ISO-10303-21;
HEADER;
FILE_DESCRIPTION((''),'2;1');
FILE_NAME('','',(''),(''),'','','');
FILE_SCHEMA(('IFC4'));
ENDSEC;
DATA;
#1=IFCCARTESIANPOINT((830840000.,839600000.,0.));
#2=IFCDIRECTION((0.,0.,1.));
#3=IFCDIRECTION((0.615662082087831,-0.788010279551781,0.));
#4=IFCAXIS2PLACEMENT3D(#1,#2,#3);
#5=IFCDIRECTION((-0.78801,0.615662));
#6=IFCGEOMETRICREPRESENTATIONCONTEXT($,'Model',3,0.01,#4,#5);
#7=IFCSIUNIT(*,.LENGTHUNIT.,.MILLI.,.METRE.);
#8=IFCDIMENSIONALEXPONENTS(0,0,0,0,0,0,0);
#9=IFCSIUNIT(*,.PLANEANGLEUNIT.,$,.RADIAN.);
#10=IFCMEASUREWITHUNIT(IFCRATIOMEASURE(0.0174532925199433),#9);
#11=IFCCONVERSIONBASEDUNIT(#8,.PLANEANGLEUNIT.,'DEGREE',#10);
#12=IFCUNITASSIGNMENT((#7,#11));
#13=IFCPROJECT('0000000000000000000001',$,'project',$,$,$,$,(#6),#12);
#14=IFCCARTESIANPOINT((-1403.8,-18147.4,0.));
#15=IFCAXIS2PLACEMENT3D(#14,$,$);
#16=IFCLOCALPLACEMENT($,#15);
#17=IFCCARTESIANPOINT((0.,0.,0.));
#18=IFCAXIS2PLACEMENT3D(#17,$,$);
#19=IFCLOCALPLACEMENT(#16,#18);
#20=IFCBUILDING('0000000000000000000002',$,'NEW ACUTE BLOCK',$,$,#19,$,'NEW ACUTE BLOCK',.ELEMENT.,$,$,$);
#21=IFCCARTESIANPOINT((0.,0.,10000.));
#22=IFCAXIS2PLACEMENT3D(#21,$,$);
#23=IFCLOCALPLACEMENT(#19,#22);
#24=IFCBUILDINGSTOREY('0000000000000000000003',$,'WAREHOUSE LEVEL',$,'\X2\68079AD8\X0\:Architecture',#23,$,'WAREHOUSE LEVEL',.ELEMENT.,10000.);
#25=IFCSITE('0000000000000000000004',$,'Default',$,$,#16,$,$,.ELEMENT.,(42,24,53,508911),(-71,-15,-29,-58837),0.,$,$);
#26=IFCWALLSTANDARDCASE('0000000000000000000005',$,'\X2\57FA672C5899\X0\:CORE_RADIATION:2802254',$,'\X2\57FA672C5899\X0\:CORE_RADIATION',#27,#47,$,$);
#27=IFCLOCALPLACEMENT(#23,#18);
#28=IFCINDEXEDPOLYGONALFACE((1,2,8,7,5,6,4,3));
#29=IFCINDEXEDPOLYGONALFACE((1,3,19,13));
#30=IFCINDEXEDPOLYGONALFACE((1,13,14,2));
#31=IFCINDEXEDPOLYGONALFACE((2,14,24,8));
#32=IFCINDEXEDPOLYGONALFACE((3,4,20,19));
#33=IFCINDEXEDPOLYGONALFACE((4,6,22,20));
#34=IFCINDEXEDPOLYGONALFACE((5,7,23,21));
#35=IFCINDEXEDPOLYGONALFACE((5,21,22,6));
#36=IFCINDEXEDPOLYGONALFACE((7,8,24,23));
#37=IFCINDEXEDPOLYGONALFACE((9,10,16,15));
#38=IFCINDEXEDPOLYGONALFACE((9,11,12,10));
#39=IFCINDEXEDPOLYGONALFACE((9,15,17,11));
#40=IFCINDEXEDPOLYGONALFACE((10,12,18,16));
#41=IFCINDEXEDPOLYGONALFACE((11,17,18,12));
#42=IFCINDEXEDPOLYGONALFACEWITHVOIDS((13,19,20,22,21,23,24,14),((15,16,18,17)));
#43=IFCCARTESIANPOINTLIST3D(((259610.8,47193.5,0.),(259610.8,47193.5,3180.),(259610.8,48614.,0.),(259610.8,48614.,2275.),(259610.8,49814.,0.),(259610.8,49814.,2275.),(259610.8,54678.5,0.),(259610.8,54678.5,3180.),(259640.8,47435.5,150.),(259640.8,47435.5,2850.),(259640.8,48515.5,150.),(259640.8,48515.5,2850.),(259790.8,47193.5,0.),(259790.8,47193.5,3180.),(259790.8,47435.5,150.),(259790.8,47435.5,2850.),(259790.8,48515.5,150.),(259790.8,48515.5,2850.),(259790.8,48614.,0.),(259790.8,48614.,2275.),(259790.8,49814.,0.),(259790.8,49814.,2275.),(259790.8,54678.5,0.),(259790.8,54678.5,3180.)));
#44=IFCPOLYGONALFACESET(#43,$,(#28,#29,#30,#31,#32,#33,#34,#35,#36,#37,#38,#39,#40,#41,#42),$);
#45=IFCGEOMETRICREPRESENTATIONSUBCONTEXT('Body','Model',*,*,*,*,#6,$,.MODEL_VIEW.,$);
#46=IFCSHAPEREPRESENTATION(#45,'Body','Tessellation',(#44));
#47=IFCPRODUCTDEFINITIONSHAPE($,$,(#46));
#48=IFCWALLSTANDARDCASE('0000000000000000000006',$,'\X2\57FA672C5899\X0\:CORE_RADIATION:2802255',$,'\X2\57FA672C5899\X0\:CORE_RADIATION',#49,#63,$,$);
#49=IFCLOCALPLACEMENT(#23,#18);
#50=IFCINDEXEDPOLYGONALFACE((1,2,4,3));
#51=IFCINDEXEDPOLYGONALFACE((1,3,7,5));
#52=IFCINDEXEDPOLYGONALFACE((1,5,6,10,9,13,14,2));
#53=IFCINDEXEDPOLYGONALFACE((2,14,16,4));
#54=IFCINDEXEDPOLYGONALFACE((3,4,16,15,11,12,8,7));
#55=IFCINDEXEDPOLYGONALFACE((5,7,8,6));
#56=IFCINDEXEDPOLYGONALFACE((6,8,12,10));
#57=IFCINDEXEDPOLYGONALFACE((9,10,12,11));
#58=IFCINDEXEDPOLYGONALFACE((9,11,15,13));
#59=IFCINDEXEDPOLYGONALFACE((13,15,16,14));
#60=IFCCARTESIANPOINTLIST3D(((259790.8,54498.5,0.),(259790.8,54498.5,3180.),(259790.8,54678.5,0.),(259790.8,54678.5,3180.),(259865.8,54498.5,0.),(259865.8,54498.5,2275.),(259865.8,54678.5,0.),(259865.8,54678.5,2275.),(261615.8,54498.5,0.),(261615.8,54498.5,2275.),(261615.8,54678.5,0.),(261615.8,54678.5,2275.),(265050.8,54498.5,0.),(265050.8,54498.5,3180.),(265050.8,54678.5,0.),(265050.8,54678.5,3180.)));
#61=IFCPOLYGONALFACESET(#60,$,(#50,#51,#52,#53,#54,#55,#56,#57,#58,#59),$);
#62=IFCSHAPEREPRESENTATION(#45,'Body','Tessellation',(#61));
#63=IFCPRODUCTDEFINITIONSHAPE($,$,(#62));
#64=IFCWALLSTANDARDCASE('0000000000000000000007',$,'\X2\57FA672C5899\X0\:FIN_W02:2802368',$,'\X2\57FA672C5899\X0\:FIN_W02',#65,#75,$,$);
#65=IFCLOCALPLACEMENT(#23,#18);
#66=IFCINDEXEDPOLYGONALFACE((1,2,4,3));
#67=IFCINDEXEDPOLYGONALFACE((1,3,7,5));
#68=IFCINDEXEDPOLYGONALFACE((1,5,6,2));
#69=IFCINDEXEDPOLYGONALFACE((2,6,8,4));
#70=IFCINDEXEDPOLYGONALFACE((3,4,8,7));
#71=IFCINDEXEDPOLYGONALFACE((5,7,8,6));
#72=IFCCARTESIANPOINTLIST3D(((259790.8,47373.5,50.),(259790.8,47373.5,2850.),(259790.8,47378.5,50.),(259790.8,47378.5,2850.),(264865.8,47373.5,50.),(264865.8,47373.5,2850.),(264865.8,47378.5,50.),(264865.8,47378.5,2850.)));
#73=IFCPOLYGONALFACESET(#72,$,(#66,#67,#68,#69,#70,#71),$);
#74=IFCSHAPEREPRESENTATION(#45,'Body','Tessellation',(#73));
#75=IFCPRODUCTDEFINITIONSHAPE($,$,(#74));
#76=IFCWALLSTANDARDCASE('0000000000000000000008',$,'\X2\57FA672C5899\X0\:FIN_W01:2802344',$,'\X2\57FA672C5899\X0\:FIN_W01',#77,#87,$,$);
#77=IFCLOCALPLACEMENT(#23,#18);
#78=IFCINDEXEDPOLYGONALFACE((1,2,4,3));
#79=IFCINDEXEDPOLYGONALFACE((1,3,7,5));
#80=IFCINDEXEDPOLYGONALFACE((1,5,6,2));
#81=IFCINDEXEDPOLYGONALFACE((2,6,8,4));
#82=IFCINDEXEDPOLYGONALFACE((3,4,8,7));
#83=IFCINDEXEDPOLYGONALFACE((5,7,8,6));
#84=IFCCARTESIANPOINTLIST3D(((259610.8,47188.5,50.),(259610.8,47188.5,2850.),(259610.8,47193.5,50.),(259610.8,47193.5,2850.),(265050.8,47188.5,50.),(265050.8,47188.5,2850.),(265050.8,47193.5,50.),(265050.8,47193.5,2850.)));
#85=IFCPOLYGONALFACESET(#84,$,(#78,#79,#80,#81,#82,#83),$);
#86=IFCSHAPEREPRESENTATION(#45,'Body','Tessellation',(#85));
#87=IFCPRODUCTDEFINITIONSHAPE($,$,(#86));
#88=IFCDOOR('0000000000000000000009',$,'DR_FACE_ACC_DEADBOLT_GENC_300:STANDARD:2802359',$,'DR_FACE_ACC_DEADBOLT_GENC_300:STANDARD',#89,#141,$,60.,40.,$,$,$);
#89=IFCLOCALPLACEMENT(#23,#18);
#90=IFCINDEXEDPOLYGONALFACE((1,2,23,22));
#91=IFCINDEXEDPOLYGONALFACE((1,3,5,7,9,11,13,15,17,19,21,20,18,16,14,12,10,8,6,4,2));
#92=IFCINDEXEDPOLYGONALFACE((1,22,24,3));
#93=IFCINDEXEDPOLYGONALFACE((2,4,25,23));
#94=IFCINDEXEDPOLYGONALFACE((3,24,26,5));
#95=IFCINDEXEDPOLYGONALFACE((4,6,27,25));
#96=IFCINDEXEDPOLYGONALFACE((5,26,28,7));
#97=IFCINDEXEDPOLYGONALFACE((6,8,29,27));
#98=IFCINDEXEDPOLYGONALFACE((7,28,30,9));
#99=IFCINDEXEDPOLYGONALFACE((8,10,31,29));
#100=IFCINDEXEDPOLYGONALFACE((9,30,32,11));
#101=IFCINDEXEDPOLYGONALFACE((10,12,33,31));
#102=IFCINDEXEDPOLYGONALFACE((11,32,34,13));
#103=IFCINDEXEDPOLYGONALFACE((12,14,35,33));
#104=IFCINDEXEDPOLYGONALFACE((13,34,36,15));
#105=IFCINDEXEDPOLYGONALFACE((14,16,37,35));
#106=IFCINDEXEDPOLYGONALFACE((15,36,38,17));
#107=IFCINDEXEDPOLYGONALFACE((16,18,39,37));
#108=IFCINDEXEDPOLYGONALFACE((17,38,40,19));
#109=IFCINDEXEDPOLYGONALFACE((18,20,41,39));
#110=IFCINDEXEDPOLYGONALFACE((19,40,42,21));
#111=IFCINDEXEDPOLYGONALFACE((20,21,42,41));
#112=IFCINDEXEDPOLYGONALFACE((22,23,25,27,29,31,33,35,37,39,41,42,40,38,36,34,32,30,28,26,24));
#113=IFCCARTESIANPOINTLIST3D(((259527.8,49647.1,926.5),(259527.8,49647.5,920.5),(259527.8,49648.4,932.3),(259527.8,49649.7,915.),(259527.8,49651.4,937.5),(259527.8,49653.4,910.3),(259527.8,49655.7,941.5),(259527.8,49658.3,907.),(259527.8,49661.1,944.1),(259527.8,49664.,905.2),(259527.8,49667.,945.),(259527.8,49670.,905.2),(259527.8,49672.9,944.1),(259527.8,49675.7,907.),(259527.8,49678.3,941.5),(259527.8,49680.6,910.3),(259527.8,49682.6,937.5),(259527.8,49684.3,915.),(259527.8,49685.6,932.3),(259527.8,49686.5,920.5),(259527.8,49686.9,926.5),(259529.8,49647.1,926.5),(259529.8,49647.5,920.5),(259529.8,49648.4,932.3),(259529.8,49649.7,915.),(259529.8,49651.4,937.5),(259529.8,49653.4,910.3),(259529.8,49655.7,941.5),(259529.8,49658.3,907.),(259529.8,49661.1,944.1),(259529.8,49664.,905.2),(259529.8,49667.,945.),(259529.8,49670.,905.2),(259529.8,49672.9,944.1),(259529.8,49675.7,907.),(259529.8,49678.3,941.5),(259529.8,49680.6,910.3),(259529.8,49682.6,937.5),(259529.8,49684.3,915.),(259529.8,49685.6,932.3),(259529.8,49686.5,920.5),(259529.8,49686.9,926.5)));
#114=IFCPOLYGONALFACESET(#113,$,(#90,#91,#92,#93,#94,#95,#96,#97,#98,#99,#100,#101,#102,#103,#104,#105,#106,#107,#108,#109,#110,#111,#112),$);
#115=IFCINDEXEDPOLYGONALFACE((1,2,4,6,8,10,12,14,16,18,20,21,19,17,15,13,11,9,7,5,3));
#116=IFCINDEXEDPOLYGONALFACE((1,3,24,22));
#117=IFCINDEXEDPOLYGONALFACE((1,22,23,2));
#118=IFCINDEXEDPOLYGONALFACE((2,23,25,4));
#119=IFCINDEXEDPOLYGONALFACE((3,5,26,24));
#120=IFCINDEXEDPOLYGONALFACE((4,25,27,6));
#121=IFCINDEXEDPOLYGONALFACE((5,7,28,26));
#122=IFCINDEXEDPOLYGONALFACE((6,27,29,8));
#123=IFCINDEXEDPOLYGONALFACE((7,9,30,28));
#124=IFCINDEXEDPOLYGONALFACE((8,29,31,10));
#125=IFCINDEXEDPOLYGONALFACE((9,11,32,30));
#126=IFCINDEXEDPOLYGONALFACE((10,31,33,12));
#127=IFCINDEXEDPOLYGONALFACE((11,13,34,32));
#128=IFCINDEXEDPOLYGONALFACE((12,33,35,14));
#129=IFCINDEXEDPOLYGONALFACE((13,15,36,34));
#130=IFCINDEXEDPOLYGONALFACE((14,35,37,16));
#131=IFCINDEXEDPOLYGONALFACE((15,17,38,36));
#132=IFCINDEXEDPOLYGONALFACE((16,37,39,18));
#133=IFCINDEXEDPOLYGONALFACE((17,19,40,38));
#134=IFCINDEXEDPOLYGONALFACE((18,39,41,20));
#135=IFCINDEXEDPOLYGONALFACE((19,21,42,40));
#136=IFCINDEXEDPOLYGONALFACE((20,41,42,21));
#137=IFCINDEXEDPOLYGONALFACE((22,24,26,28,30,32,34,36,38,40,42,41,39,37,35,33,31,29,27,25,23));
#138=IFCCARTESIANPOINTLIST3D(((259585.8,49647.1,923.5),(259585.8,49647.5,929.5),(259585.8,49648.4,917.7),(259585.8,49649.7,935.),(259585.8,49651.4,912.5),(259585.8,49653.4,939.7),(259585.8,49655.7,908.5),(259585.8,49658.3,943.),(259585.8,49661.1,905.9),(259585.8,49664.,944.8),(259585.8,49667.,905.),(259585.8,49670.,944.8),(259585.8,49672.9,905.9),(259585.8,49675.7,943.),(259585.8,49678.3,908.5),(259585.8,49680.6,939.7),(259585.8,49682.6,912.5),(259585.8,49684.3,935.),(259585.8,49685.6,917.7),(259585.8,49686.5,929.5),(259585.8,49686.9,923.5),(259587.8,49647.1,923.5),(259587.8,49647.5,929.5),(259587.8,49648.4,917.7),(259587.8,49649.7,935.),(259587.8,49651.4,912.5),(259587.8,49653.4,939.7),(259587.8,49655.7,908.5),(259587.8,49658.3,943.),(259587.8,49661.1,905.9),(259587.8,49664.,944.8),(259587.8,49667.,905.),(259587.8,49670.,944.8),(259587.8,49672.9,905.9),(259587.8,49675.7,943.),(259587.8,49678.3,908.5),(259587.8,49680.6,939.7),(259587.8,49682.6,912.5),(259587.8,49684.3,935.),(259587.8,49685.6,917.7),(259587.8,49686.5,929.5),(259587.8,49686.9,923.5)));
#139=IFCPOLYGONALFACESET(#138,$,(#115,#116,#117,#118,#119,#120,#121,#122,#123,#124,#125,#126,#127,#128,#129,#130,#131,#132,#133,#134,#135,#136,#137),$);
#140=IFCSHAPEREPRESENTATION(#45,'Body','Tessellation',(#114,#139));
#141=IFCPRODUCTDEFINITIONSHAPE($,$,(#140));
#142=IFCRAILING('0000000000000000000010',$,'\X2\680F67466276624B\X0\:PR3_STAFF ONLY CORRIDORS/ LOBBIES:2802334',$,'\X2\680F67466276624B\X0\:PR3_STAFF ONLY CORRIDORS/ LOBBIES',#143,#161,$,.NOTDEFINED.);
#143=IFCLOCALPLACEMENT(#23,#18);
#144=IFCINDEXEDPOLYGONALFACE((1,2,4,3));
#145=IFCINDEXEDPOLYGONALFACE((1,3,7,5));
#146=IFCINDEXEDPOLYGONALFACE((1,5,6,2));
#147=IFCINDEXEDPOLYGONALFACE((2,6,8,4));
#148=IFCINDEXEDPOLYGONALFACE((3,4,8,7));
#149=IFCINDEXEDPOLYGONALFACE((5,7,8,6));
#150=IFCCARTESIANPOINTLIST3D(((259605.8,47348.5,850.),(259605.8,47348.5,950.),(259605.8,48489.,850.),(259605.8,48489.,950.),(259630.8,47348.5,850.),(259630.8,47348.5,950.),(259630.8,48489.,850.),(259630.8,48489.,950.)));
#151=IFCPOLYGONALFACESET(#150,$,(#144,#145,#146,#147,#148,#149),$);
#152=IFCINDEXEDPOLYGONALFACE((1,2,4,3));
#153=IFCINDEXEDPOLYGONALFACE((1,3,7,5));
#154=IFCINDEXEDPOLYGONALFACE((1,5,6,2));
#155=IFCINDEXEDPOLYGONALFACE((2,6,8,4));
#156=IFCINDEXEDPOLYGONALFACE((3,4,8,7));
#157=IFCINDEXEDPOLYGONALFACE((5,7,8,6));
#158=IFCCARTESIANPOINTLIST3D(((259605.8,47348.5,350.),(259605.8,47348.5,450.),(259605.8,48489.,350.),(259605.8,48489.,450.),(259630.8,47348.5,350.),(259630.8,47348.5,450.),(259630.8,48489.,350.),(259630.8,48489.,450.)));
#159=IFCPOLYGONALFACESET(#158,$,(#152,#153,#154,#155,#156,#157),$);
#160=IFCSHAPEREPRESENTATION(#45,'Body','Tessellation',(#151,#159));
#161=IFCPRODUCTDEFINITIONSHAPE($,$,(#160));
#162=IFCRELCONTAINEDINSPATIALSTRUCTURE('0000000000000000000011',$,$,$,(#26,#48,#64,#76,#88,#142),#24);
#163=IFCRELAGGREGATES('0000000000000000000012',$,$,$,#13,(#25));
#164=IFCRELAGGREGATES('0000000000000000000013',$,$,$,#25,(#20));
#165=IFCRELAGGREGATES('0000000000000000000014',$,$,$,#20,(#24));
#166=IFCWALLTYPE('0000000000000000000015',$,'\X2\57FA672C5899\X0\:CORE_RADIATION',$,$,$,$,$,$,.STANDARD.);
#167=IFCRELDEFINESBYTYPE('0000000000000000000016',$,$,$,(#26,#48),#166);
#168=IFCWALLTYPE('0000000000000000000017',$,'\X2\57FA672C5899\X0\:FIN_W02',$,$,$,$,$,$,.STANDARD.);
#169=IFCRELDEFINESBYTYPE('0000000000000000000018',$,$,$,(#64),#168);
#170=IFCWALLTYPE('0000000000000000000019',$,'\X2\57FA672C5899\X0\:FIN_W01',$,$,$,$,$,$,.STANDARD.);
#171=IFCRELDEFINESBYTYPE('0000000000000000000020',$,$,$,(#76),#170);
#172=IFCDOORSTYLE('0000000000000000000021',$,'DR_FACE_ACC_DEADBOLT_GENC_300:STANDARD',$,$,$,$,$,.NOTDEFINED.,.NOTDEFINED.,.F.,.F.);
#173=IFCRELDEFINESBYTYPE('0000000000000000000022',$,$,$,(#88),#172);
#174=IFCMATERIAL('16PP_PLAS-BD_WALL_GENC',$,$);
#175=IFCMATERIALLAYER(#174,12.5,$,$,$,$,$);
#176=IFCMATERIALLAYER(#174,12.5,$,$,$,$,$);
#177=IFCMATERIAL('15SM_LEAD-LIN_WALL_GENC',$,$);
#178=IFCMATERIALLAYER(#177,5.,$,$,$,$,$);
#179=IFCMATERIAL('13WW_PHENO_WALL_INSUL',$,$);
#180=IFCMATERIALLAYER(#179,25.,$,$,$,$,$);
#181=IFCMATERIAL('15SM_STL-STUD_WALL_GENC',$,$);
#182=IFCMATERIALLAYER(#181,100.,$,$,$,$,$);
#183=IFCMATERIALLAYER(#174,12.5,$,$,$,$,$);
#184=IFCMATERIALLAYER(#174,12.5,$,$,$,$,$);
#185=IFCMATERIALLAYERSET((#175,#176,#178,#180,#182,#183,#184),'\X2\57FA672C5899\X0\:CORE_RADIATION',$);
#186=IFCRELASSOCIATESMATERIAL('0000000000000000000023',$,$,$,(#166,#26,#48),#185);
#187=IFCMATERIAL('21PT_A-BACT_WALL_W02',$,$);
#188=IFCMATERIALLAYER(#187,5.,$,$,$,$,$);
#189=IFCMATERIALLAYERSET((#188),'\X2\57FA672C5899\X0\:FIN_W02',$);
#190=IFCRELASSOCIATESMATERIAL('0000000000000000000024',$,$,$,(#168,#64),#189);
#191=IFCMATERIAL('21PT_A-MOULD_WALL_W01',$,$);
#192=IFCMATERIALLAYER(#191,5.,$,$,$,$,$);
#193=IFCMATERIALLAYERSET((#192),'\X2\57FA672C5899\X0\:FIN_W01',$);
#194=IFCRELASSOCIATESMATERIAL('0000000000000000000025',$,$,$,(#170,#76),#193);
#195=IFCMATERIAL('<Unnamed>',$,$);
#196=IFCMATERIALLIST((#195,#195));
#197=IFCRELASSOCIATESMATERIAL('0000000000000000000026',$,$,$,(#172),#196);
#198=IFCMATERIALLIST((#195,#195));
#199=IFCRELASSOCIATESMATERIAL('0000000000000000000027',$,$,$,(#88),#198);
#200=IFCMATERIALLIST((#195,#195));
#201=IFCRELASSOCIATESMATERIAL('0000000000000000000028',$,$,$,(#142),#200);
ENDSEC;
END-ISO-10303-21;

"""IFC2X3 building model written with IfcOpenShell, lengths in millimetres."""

from ifc_helpers import new_model, entity, si_unit, converted_unit, direction, frame, frame_2d, origin, place, context, subcontext, project, spatial, rectangle, circle, extrude, source, transform, mapped, material, material_list, layer, layer_set, layer_usage, type_object, type_shapes, element, save


model = new_model("IFC2X3")

# Units and contexts
model_context = context("Model", 3, precision=0.01, world=frame((830840000.0, 839600000.0, 0.0), z_axis=(0.0, 0.0, 1.0), x_axis=(0.615662082087831, -0.788010279551781, 0.0)), true_north=direction((-0.78801, 0.615662)))
body_context = subcontext(model_context, "Body", "Model", "MODEL_VIEW")
ifc_project = project(units=[si_unit("LENGTHUNIT", "METRE", prefix="MILLI"), converted_unit("PLANEANGLEUNIT", "DEGREE", entity("IfcRatioMeasure", 0.0174532925199433), si_unit("PLANEANGLEUNIT", "RADIAN"), dimensions=[0, 0, 0, 0, 0, 0, 0])], contexts=[model_context])

# Site, building, storey
site_placement = place(None, frame((-1403.8, -18147.4, 0.0)))
site = spatial("IfcSite", under=ifc_project, at=site_placement, Name="Default", CompositionType="ELEMENT", RefLatitude=(42, 24, 53, 508911), RefLongitude=(-71, -15, -29, -58837), RefElevation=0.0)
building_placement = place(site_placement, origin())
building = spatial("IfcBuilding", under=site, at=building_placement, Name="NEW ACUTE BLOCK", LongName="NEW ACUTE BLOCK", CompositionType="ELEMENT")
storey_placement = place(building_placement, frame((0.0, 0.0, 10000.0)))
storey = spatial("IfcBuildingStorey", under=building, at=storey_placement, Name="WAREHOUSE LEVEL", ObjectType="标高:Architecture", LongName="WAREHOUSE LEVEL", CompositionType="ELEMENT", Elevation=10000.0)

# Wall, openings
ifc_material_1 = material(Name="16PP_PLAS-BD_WALL_GENC")
ifc_layer_1 = layer(ifc_material_1, 12.5)
ifc_layer_2 = layer(ifc_material_1, 12.5)
ifc_material_2 = material(Name="15SM_LEAD-LIN_WALL_GENC")
ifc_layer_3 = layer(ifc_material_2, 5.0)
ifc_material_3 = material(Name="13WW_PHENO_WALL_INSUL")
ifc_layer_4 = layer(ifc_material_3, 25.0)
ifc_material_4 = material(Name="15SM_STL-STUD_WALL_GENC")
ifc_layer_5 = layer(ifc_material_4, 100.0)
ifc_layer_6 = layer(ifc_material_1, 12.5)
ifc_layer_7 = layer(ifc_material_1, 12.5)
ifc_layer_set_1 = layer_set([ifc_layer_1, ifc_layer_2, ifc_layer_3, ifc_layer_4, ifc_layer_5, ifc_layer_6, ifc_layer_7], Name="基本墙:CORE_RADIATION")
ifc_layer_usage_1 = layer_usage(ifc_layer_set_1, "AXIS2", "POSITIVE", -90.0)
wall_type_1 = type_object("IfcWallType", Name="基本墙:CORE_RADIATION", PredefinedType="STANDARD", material=ifc_layer_set_1)
wall_1_placement = place(storey_placement, frame((259700.8, 54678.5, 0.0), z_axis=(0.0, 0.0, 1.0), x_axis=(0.0, -1.0, 0.0)))
wall_1 = element("IfcWallStandardCase", 1, at=wall_1_placement, inside=storey, type_object=wall_type_1, material=ifc_layer_usage_1, Name="基本墙:CORE_RADIATION:2802254", ObjectType="基本墙:CORE_RADIATION", context=body_context, shape_type="SweptSolid", body=[
    extrude(rectangle(XDim=7485.0, YDim=180.0, at=frame_2d((3742.5, 0.0), x_axis=(-1.0, 0.0))), origin(), (0.0, 0.0, 1.0), 3180.0),
])
opening_1_placement = place(wall_1_placement, frame((7243.0, -60.0, 150.0)))
element("IfcOpeningElement", 2, at=opening_1_placement, cuts=wall_1, ObjectType="Recess", context=body_context, shape_type="SweptSolid", body=[
    extrude(rectangle(XDim=2700.0, YDim=1080.0, at=frame_2d((0.0, 0.0), x_axis=(0.0, 1.0))), frame((-540.0, 0.0, 1350.0), z_axis=(0.0, 1.0, 0.0), x_axis=(1.0, 0.0, 0.0)), (0.0, 0.0, 1.0), 155.0),
])
opening_2_placement = place(wall_1_placement, frame((6064.5, -90.0, 0.0), z_axis=(0.0, 0.0, 1.0), x_axis=(0.0, 1.0, 0.0)))
element("IfcOpeningElement", 3, at=opening_2_placement, cuts=wall_1, ObjectType="Opening", context=body_context, shape_type="SweptSolid", body=[
    extrude(rectangle(XDim=2275.0, YDim=1200.0, at=frame_2d((0.0, 0.0), x_axis=(1.0, 0.0))), frame((0.0, 600.0, 1137.5), z_axis=(1.0, 0.0, 0.0), x_axis=(0.0, 0.0, -1.0)), (0.0, 0.0, 1.0), 180.0),
])

# Wall, opening
ifc_layer_usage_2 = layer_usage(ifc_layer_set_1, "AXIS2", "NEGATIVE", 90.0)
wall_2_placement = place(storey_placement, frame((259790.8, 54588.5, 0.0)))
wall_2 = element("IfcWallStandardCase", 4, at=wall_2_placement, inside=storey, type_object=wall_type_1, material=ifc_layer_usage_2, Name="基本墙:CORE_RADIATION:2802255", ObjectType="基本墙:CORE_RADIATION", context=body_context, shape_type="SweptSolid", body=[
    extrude(rectangle(XDim=5260.0, YDim=180.0, at=frame_2d((2630.0, 0.0), x_axis=(-1.0, 0.0))), origin(), (0.0, 0.0, 1.0), 3180.0),
])
opening_3_placement = place(wall_2_placement, frame((75.0, -90.0, 0.0)))
element("IfcOpeningElement", 5, at=opening_3_placement, cuts=wall_2, ObjectType="Opening", context=body_context, shape_type="SweptSolid", body=[
    extrude(rectangle(XDim=2275.0, YDim=1750.0, at=frame_2d((0.0, 0.0), x_axis=(1.0, 0.0))), frame((875.0, 0.0, 1137.5), z_axis=(0.0, 1.0, 0.0), x_axis=(0.0, 0.0, -1.0)), (0.0, 0.0, 1.0), 180.0),
])

# Shared definitions
ifc_material_5 = material(Name="21PT_A-BACT_WALL_W02")
ifc_layer_8 = layer(ifc_material_5, 5.0)
ifc_layer_set_2 = layer_set([ifc_layer_8], Name="基本墙:FIN_W02")
wall_type_2 = type_object("IfcWallType", Name="基本墙:FIN_W02", PredefinedType="STANDARD", material=ifc_layer_set_2)

# Wall
ifc_layer_usage_3 = layer_usage(ifc_layer_set_2, "AXIS2", "NEGATIVE", 2.5)
wall_3_placement = place(storey_placement, frame((259790.8, 47376.0, 50.0)))
element("IfcWallStandardCase", 6, at=wall_3_placement, inside=storey, type_object=wall_type_2, material=ifc_layer_usage_3, Name="基本墙:FIN_W02:2802368", ObjectType="基本墙:FIN_W02", context=body_context, shape_type="SweptSolid", body=[
    extrude(rectangle(XDim=5075.0, YDim=5.0, at=frame_2d((2537.5, 0.0), x_axis=(-1.0, 0.0))), origin(), (0.0, 0.0, 1.0), 2800.0),
])

# Shared definitions
ifc_material_6 = material(Name="21PT_A-MOULD_WALL_W01")
ifc_layer_9 = layer(ifc_material_6, 5.0)
ifc_layer_set_3 = layer_set([ifc_layer_9], Name="基本墙:FIN_W01")
wall_type_3 = type_object("IfcWallType", Name="基本墙:FIN_W01", PredefinedType="STANDARD", material=ifc_layer_set_3)

# Wall
ifc_layer_usage_4 = layer_usage(ifc_layer_set_3, "AXIS2", "POSITIVE", -2.5)
wall_4_placement = place(storey_placement, frame((259610.8, 47191.0, 50.0)))
element("IfcWallStandardCase", 7, at=wall_4_placement, inside=storey, type_object=wall_type_3, material=ifc_layer_usage_4, Name="基本墙:FIN_W01:2802344", ObjectType="基本墙:FIN_W01", context=body_context, shape_type="SweptSolid", body=[
    extrude(rectangle(XDim=5440.0, YDim=5.0, at=frame_2d((2720.0, 0.0), x_axis=(-1.0, 0.0))), origin(), (0.0, 0.0, 1.0), 2800.0),
])

# Door
ifc_material_7 = material(Name="<Unnamed>")
ifc_material_list_1 = material_list([ifc_material_7, ifc_material_7])
ifc_material_list_2 = material_list([ifc_material_7, ifc_material_7])
door_style_1 = type_object("IfcDoorStyle", Name="DR_FACE_ACC_DEADBOLT_GENC_300:STANDARD", ConstructionType="NOTDEFINED", OperationType="NOTDEFINED", ParameterTakesPrecedence=False, Sizeable=False, material=ifc_material_list_2)
shared_shape_1 = source(origin(), body_context, "Body", "SweptSolid", [
    extrude(circle(Radius=20.0, at=frame_2d((0.0, 0.0), x_axis=(1.0, 0.0))), frame((0.0, 0.0, -58.0), z_axis=(0.0, 0.0, 1.0), x_axis=(-1.0, 0.0, 0.0)), (0.0, 0.0, 1.0), 2.0),
    extrude(circle(Radius=20.0, at=frame_2d((0.0, 0.0), x_axis=(1.0, 0.0))), origin(), (0.0, 0.0, 1.0), 2.0),
])
type_shapes(door_style_1, [shared_shape_1])
door_1_placement = place(storey_placement, frame((259585.8, 49667.0, 925.0), z_axis=(1.0, 0.0, 0.0), x_axis=(0.0, 0.0, -1.0)))
element("IfcDoor", 8, at=door_1_placement, inside=storey, type_object=door_style_1, material=ifc_material_list_1, Name="DR_FACE_ACC_DEADBOLT_GENC_300:STANDARD:2802359", ObjectType="DR_FACE_ACC_DEADBOLT_GENC_300:STANDARD", OverallHeight=60.0, OverallWidth=40.0, context=body_context, shape_type="MappedRepresentation", body=[
    mapped(shared_shape_1, transform((0.0, 0.0, 0.0), scale=1.0)),
])

# Railing
ifc_material_list_3 = material_list([ifc_material_7, ifc_material_7])
railing_1_placement = place(storey_placement, frame((259605.8, 47348.5, 350.0)))
element("IfcRailing", 9, at=railing_1_placement, inside=storey, material=ifc_material_list_3, Name="栏杆扶手:PR3_STAFF ONLY CORRIDORS/ LOBBIES:2802334", ObjectType="栏杆扶手:PR3_STAFF ONLY CORRIDORS/ LOBBIES", PredefinedType="NOTDEFINED", context=body_context, shape_type="SweptSolid", body=[
    extrude(rectangle(XDim=1140.5, YDim=25.0, at=frame_2d((0.0, 0.0), x_axis=(1.0, 0.0))), frame((12.5, 570.3, 500.0), z_axis=(0.0, 0.0, 1.0), x_axis=(0.0, 1.0, 0.0)), (0.0, 0.0, 1.0), 100.0),
    extrude(rectangle(XDim=1140.5, YDim=25.0, at=frame_2d((0.0, 0.0), x_axis=(1.0, 0.0))), frame((12.5, 570.3, 0.0), z_axis=(0.0, 0.0, 1.0), x_axis=(0.0, 1.0, 0.0)), (0.0, 0.0, 1.0), 100.0),
])

save(model, "model.ifc")
